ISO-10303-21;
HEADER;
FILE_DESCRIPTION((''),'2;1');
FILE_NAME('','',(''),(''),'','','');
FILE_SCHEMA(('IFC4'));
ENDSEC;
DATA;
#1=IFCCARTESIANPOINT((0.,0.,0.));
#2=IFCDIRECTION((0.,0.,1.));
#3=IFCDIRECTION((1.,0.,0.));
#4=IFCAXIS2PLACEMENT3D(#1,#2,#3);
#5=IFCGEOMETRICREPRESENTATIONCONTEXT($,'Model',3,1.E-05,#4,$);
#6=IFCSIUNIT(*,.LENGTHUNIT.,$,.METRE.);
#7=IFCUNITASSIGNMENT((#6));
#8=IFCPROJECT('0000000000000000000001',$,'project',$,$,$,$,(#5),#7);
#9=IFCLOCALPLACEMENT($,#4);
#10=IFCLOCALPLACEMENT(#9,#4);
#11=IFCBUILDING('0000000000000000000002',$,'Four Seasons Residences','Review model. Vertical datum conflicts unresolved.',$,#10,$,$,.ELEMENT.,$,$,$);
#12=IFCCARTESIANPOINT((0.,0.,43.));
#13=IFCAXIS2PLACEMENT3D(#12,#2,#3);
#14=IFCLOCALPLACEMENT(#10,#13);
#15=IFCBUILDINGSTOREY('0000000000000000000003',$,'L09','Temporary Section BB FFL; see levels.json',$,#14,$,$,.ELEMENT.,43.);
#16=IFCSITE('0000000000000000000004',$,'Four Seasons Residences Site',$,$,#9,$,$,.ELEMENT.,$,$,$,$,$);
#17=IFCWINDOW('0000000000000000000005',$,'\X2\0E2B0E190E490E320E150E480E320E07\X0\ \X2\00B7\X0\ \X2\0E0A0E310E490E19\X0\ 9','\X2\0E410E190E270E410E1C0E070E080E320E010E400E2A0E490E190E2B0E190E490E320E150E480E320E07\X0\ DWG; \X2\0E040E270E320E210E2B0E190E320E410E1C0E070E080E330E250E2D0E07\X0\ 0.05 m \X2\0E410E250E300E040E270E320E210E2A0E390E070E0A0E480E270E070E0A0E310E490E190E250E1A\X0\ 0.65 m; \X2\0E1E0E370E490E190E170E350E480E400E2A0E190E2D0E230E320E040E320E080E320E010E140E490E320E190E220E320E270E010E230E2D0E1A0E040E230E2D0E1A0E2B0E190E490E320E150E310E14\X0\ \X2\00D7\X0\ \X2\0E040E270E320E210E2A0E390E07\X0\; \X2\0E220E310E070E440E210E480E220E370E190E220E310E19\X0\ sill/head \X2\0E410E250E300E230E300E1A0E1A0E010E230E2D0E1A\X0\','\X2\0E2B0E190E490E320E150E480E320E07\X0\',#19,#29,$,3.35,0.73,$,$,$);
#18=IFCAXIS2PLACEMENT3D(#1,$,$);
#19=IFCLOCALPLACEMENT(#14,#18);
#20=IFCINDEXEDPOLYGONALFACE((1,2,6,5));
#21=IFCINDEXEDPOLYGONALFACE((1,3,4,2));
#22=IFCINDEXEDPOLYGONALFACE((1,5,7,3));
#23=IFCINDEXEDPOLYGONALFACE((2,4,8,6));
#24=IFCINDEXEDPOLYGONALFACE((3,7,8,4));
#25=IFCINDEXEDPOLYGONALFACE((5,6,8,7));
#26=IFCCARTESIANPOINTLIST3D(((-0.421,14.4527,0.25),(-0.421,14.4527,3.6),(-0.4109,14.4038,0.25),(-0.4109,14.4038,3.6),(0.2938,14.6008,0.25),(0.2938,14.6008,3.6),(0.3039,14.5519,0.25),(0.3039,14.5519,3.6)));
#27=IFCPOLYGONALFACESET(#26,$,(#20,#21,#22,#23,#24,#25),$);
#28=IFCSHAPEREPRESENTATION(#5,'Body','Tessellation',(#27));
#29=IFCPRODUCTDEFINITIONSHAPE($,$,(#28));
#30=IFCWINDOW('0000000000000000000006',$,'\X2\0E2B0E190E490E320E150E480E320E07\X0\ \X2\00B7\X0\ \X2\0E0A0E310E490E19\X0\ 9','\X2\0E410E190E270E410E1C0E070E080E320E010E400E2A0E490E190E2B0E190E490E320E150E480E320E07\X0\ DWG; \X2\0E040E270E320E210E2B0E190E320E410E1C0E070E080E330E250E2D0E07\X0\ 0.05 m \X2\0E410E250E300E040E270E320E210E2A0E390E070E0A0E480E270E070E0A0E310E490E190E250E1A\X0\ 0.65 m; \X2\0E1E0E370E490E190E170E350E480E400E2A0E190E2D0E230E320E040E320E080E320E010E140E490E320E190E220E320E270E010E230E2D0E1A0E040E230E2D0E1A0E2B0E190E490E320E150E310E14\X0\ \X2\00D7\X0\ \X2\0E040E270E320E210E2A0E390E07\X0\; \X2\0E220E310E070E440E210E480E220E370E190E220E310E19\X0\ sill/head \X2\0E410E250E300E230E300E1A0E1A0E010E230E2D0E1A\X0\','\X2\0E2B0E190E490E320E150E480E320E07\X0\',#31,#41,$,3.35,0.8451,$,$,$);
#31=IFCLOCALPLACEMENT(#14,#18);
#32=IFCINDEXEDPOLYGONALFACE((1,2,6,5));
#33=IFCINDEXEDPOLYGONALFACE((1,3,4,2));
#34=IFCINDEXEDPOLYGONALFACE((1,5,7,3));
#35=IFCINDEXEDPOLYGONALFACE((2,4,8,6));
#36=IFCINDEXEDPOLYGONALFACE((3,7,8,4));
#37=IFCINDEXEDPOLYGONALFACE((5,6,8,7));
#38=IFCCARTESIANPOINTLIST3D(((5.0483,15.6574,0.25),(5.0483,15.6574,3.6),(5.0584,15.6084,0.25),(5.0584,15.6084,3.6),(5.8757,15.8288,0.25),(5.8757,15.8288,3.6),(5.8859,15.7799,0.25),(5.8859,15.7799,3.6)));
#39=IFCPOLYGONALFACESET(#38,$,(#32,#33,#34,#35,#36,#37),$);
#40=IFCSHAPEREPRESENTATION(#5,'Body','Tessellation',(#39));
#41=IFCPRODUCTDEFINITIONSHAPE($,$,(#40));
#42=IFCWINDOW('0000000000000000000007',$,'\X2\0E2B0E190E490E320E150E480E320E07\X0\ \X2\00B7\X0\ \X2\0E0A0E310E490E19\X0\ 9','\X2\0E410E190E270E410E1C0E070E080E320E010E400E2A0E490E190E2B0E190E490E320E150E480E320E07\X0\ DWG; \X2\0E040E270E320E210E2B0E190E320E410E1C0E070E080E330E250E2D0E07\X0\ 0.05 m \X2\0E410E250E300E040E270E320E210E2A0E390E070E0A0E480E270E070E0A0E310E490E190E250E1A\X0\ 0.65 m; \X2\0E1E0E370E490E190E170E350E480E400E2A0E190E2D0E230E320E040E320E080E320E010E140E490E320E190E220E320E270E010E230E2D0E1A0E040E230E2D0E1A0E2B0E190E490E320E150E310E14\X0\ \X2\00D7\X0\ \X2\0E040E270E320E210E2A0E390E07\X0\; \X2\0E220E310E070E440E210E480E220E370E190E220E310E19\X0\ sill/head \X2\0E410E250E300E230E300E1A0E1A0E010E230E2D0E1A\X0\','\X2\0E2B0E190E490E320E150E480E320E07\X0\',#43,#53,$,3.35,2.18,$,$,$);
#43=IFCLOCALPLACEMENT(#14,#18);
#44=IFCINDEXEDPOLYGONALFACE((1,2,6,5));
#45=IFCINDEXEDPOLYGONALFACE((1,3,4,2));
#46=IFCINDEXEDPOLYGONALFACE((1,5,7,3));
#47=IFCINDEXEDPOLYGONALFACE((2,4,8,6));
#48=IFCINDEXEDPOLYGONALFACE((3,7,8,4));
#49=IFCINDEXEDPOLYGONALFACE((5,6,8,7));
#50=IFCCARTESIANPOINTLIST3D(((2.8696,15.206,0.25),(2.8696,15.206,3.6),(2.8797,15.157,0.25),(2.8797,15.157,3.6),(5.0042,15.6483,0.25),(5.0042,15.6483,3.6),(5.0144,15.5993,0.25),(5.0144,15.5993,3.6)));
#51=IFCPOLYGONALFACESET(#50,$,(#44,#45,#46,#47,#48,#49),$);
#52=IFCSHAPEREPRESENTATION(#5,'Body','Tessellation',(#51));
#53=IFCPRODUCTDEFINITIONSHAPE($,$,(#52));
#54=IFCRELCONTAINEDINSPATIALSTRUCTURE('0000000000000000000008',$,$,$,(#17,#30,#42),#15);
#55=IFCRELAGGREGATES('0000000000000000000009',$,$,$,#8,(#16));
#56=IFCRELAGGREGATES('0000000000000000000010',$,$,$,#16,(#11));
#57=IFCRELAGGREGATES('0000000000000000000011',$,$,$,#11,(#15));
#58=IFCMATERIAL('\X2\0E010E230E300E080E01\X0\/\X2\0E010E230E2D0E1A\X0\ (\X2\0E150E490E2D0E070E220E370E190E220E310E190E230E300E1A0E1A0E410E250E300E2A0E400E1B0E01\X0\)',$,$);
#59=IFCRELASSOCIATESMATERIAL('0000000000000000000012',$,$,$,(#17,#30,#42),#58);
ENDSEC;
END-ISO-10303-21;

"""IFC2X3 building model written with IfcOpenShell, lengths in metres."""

from ifc_helpers import new_model, si_unit, frame, origin_with_axes, place, context, project, spatial, polyline, outline, extrude, material, element, save


model = new_model("IFC2X3")

# Units and contexts
model_context = context("Model", 3, precision=1e-05, world=origin_with_axes())
ifc_project = project(units=[si_unit("LENGTHUNIT", "METRE")], contexts=[model_context])

# Site, building, storey
site_placement = place(None, origin_with_axes())
site = spatial("IfcSite", under=ifc_project, at=site_placement, Name="Four Seasons Residences Site", CompositionType="ELEMENT")
building_placement = place(site_placement, origin_with_axes())
building = spatial("IfcBuilding", under=site, at=building_placement, Name="Four Seasons Residences", Description="Review model. Vertical datum conflicts unresolved.", CompositionType="ELEMENT")
storey_placement = place(building_placement, frame((0.0, 0.0, 43.0), z_axis=(0.0, 0.0, 1.0), x_axis=(1.0, 0.0, 0.0)))
storey = spatial("IfcBuildingStorey", under=building, at=storey_placement, Name="L09", Description="Temporary Section BB FFL; see levels.json", CompositionType="ELEMENT", Elevation=43.0)

# Windows
ifc_material = material(Name="กระจก/กรอบ (ต้องยืนยันระบบและสเปก)")
window_1_placement = place(storey_placement, origin_with_axes())
element("IfcWindow", 1, at=window_1_placement, inside=storey, material=ifc_material, Name="หน้าต่าง · ชั้น 9", Description="แนวแผงจากเส้นหน้าต่าง DWG; ความหนาแผงจำลอง 0.05 m และความสูงช่วงชั้นลบ 0.65 m; พื้นที่เสนอราคาจากด้านยาวกรอบครอบหน้าตัด × ความสูง; ยังไม่ยืนยัน sill/head และระบบกรอบ", ObjectType="หน้าต่าง", OverallHeight=3.35, OverallWidth=0.73, context=model_context, shape_type="SweptSolid", body=[
    extrude(outline(polyline([(-0.4109, 14.4038), (-0.421, 14.4527), (0.2938, 14.6008), (0.3039, 14.5519), (-0.4109, 14.4038)])), frame((0.0, 0.0, 0.25), z_axis=(0.0, 0.0, 1.0), x_axis=(1.0, 0.0, 0.0)), (0.0, 0.0, 1.0), 3.35),
])
window_2_placement = place(storey_placement, origin_with_axes())
element("IfcWindow", 2, at=window_2_placement, inside=storey, material=ifc_material, Name="หน้าต่าง · ชั้น 9", Description="แนวแผงจากเส้นหน้าต่าง DWG; ความหนาแผงจำลอง 0.05 m และความสูงช่วงชั้นลบ 0.65 m; พื้นที่เสนอราคาจากด้านยาวกรอบครอบหน้าตัด × ความสูง; ยังไม่ยืนยัน sill/head และระบบกรอบ", ObjectType="หน้าต่าง", OverallHeight=3.35, OverallWidth=0.8451, context=model_context, shape_type="SweptSolid", body=[
    extrude(outline(polyline([(5.0584, 15.6084), (5.0483, 15.6574), (5.8757, 15.8288), (5.8859, 15.7799), (5.0584, 15.6084)])), frame((0.0, 0.0, 0.25), z_axis=(0.0, 0.0, 1.0), x_axis=(1.0, 0.0, 0.0)), (0.0, 0.0, 1.0), 3.35),
])
window_3_placement = place(storey_placement, origin_with_axes())
element("IfcWindow", 3, at=window_3_placement, inside=storey, material=ifc_material, Name="หน้าต่าง · ชั้น 9", Description="แนวแผงจากเส้นหน้าต่าง DWG; ความหนาแผงจำลอง 0.05 m และความสูงช่วงชั้นลบ 0.65 m; พื้นที่เสนอราคาจากด้านยาวกรอบครอบหน้าตัด × ความสูง; ยังไม่ยืนยัน sill/head และระบบกรอบ", ObjectType="หน้าต่าง", OverallHeight=3.35, OverallWidth=2.18, context=model_context, shape_type="SweptSolid", body=[
    extrude(outline(polyline([(2.8797, 15.157), (2.8696, 15.206), (5.0042, 15.6483), (5.0144, 15.5993), (2.8797, 15.157)])), frame((0.0, 0.0, 0.25), z_axis=(0.0, 0.0, 1.0), x_axis=(1.0, 0.0, 0.0)), (0.0, 0.0, 1.0), 3.35),
])

save(model, "model.ifc")
